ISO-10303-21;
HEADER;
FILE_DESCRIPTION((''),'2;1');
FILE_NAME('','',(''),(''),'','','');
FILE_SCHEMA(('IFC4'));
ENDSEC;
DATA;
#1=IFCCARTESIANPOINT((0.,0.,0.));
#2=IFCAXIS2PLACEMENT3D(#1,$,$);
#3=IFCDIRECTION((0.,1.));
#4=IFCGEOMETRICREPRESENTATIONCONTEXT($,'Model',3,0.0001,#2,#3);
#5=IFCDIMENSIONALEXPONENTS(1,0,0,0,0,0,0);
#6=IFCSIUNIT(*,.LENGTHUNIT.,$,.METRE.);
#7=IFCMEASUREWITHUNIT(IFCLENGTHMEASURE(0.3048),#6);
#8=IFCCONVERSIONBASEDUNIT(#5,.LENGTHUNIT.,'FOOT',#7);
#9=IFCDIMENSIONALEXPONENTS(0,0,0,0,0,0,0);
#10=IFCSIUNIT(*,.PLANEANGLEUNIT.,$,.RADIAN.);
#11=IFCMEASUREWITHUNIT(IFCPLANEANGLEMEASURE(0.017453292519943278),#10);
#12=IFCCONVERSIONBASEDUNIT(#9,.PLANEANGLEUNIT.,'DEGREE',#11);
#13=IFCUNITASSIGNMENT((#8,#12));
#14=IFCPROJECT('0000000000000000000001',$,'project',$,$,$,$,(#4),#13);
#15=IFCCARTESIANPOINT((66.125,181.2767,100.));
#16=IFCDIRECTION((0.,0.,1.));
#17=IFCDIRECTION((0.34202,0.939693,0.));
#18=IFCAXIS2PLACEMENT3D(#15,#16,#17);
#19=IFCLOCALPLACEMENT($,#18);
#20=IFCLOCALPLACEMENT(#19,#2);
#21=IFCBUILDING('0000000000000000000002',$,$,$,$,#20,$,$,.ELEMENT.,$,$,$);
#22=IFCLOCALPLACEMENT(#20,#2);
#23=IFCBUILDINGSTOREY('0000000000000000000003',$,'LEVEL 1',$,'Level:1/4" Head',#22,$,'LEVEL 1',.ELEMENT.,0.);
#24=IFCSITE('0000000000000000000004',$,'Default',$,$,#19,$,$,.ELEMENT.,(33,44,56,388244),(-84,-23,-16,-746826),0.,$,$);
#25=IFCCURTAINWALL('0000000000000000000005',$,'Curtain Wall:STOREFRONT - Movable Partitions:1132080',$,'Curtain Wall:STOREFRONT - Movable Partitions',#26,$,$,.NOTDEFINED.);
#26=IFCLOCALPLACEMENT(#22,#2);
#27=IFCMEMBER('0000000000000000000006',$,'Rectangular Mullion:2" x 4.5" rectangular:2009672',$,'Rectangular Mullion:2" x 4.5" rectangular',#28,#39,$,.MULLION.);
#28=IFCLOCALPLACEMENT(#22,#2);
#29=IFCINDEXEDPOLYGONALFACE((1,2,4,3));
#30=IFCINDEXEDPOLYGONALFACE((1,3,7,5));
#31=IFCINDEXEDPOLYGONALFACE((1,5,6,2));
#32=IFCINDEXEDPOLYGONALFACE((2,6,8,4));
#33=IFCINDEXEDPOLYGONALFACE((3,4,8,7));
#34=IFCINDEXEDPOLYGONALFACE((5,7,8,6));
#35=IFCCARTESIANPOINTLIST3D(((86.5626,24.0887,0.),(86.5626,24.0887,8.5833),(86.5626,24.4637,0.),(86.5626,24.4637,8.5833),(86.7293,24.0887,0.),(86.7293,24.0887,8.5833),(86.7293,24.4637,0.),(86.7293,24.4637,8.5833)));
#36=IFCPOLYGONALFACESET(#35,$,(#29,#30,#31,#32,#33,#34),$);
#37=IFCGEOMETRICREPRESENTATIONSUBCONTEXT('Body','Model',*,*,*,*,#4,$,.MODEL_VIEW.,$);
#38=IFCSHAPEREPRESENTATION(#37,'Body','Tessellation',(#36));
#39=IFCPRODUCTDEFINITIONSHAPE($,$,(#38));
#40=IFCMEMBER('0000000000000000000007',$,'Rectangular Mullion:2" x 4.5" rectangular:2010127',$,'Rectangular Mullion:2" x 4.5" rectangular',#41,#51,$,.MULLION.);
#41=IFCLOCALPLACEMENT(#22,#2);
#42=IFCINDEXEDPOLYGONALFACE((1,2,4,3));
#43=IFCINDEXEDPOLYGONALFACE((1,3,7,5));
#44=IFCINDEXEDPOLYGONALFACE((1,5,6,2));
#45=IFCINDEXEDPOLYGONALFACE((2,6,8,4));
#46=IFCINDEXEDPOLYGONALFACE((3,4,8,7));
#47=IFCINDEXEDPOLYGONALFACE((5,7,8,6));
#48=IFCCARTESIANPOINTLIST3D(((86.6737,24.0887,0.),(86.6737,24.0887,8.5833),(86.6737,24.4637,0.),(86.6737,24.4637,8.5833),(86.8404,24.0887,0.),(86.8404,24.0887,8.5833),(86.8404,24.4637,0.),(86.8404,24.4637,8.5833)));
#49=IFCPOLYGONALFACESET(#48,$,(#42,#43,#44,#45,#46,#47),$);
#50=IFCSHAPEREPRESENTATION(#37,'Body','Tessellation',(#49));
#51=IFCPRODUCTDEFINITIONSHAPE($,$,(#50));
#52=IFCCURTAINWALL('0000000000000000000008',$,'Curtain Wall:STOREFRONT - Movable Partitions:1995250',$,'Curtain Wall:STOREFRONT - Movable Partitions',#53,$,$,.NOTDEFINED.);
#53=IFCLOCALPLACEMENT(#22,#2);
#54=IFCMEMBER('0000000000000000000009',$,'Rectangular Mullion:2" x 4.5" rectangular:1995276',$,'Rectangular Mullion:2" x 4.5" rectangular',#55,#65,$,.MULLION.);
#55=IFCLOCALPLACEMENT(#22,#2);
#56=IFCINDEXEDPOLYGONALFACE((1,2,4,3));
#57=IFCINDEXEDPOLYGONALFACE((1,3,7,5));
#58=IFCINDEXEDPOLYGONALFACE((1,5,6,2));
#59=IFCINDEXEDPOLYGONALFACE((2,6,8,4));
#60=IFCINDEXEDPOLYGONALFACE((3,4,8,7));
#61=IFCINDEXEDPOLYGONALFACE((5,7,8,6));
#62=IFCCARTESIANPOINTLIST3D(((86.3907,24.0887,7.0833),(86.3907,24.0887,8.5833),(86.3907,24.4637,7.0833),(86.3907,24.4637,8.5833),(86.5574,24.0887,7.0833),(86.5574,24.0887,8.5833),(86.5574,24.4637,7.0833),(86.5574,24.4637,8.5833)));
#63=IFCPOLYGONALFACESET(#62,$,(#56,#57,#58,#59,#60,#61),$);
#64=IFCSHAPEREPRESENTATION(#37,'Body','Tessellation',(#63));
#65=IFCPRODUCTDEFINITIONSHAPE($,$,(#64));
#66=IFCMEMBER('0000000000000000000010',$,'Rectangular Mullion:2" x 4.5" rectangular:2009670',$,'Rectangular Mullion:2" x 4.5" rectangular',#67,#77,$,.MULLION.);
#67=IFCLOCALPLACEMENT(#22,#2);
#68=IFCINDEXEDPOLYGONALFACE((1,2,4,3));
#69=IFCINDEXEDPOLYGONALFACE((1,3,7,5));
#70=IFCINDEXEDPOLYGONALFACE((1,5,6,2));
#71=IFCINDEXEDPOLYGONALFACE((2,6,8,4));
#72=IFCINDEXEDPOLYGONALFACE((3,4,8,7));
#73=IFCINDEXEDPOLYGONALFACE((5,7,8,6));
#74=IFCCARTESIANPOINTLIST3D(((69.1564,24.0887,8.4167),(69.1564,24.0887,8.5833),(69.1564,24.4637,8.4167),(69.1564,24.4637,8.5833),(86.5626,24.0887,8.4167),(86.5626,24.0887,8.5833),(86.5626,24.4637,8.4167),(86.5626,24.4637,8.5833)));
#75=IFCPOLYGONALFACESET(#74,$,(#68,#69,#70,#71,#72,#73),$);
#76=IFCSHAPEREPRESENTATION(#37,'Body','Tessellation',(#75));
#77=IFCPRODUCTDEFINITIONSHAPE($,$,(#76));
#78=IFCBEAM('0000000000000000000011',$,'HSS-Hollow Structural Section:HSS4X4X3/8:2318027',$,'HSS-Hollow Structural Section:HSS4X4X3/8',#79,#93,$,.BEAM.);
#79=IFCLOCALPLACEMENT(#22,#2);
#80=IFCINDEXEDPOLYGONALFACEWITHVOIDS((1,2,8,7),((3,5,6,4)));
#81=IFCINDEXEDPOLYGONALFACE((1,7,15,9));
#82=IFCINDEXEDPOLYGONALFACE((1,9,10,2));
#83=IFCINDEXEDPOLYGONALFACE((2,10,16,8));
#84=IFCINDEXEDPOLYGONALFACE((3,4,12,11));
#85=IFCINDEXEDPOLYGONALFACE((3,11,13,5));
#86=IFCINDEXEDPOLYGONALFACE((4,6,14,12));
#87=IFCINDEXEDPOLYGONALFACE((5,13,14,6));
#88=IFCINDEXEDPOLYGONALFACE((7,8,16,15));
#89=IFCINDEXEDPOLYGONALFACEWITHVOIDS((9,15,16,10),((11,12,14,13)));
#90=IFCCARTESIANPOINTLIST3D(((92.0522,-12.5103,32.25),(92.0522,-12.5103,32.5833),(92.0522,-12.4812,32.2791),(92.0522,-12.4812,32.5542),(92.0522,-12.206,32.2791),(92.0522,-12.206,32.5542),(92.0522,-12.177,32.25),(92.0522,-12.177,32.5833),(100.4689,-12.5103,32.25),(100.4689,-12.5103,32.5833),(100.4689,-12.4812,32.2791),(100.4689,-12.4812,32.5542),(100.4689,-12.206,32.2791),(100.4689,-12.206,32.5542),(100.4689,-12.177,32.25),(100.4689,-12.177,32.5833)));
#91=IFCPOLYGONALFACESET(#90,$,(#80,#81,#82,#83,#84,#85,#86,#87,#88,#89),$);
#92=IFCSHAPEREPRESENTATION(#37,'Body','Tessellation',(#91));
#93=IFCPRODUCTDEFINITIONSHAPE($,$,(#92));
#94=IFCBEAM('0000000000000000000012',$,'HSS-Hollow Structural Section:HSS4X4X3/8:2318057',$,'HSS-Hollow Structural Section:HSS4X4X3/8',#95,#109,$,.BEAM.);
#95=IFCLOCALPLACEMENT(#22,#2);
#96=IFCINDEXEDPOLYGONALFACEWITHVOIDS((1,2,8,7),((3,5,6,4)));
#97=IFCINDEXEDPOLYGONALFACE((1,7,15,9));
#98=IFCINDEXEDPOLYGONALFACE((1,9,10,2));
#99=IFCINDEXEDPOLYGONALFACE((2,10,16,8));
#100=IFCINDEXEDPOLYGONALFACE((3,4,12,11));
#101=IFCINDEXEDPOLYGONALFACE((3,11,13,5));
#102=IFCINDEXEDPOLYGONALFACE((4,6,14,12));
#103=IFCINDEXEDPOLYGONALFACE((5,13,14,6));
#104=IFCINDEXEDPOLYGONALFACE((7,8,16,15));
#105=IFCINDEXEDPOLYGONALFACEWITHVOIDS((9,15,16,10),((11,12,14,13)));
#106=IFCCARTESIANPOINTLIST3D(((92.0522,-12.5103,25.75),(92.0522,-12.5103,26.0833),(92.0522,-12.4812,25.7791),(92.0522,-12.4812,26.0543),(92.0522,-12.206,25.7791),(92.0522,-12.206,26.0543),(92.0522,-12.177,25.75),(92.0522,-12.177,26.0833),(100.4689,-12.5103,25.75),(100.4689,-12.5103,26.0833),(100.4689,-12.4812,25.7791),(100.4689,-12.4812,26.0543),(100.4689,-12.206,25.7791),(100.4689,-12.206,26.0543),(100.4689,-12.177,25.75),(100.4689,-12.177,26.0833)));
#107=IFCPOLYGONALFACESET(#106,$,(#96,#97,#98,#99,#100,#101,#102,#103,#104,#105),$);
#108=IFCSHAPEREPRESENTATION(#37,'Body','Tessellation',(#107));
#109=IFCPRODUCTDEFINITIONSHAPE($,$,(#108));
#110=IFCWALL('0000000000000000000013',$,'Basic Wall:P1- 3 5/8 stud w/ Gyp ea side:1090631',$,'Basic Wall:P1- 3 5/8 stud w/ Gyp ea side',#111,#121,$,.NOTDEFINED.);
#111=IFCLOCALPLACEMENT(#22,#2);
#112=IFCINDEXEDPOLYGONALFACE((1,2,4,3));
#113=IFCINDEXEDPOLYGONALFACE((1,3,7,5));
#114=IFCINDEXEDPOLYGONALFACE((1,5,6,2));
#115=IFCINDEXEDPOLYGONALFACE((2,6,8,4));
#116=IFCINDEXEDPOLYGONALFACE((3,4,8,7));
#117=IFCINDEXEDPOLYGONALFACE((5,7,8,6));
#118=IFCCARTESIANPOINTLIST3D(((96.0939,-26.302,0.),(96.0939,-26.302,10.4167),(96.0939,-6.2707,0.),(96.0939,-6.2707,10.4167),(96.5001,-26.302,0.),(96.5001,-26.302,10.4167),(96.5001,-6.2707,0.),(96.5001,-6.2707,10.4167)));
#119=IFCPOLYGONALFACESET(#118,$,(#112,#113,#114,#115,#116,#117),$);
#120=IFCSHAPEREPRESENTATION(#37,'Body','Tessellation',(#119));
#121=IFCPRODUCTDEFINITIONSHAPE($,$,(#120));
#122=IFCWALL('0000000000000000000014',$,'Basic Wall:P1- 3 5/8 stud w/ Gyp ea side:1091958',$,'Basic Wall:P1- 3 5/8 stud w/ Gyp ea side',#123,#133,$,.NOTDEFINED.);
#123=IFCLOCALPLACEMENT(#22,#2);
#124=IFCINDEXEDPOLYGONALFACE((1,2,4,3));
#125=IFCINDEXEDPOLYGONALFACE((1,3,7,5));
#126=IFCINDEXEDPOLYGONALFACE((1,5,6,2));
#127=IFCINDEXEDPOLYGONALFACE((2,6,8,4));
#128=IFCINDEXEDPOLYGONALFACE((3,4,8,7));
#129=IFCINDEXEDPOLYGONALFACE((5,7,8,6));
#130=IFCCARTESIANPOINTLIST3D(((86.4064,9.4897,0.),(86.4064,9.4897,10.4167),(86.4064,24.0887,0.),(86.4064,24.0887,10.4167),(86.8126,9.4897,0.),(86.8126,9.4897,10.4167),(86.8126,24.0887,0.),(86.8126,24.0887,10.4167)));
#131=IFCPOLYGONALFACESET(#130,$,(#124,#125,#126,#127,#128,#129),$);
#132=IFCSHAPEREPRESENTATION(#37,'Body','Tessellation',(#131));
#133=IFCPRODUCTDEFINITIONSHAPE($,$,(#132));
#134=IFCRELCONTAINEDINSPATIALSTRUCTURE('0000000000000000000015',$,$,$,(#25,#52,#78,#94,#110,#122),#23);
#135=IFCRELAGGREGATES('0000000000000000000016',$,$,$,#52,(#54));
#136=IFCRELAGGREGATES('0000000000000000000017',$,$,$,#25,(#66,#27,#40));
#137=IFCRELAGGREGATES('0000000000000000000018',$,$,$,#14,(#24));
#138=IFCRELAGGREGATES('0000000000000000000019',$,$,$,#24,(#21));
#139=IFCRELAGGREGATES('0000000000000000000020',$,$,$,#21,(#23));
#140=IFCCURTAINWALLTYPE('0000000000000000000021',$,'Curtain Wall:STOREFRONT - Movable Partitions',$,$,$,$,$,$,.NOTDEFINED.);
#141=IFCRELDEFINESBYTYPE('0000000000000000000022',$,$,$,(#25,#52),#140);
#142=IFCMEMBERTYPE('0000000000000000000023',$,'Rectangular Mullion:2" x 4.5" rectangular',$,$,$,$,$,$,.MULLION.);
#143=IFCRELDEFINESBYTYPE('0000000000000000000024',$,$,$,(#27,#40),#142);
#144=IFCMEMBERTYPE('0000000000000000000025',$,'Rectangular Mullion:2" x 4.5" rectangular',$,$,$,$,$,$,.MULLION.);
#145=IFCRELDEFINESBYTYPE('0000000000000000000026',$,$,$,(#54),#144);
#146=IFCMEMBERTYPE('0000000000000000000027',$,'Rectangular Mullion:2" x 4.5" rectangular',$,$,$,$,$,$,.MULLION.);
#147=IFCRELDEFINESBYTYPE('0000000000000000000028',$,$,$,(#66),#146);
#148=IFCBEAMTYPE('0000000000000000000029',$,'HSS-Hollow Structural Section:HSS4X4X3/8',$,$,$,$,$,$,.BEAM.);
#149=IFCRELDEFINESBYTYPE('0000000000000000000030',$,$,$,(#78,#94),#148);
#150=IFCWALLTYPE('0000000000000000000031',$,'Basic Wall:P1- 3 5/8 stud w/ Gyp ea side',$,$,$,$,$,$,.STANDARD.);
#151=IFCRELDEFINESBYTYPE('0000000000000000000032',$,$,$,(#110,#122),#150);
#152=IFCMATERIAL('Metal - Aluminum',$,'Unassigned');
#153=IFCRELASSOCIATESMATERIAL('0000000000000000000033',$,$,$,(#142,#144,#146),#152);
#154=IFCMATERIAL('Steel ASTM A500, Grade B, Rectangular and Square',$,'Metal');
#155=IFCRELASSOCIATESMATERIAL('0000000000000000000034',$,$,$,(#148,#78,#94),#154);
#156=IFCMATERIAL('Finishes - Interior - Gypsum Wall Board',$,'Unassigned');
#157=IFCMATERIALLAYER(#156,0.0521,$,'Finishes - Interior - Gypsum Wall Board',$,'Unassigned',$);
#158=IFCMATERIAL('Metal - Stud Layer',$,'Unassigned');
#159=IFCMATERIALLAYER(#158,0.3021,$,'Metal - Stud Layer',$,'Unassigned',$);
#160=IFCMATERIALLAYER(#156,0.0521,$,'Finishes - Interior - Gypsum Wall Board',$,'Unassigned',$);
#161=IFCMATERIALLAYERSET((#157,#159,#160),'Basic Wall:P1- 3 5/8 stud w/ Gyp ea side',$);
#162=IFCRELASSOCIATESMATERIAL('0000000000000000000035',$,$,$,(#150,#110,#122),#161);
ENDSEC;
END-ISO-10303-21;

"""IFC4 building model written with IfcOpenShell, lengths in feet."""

from ifc_helpers import new_model, entity, si_unit, converted_unit, direction, frame, frame_2d, origin, origin_2d_with_axis, place, context, subcontext, project, spatial, rectangle, extrude, boolean, source, transform, mapped, material, layer, layer_set, layer_usage, material_profile, profile_set, type_object, type_shapes, element, aggregate, save


model = new_model("IFC4")

# Units and contexts
model_context = context("Model", 3, precision=0.0001, world=origin(), true_north=direction((0.0, 1.0)))
body_context = subcontext(model_context, "Body", "Model", "MODEL_VIEW")
ifc_project = project(units=[converted_unit("LENGTHUNIT", "FOOT", entity("IfcLengthMeasure", 0.3048), si_unit("LENGTHUNIT", "METRE"), dimensions=[1, 0, 0, 0, 0, 0, 0]), converted_unit("PLANEANGLEUNIT", "DEGREE", entity("IfcPlaneAngleMeasure", 0.017453292519943278), si_unit("PLANEANGLEUNIT", "RADIAN"), dimensions=[0, 0, 0, 0, 0, 0, 0])], contexts=[model_context])

# Site, building, storey
site_placement = place(None, frame((66.125, 181.2767, 100.0), z_axis=(0.0, 0.0, 1.0), x_axis=(0.34202, 0.939693, 0.0)))
site = spatial("IfcSite", under=ifc_project, at=site_placement, Name="Default", CompositionType="ELEMENT", RefLatitude=(33, 44, 56, 388244), RefLongitude=(-84, -23, -16, -746826), RefElevation=0.0)
building_placement = place(site_placement, origin())
building = spatial("IfcBuilding", under=site, at=building_placement, CompositionType="ELEMENT")
storey_placement = place(building_placement, origin())
storey = spatial("IfcBuildingStorey", under=building, at=storey_placement, Name="LEVEL 1", ObjectType="Level:1/4\" Head", LongName="LEVEL 1", CompositionType="ELEMENT", Elevation=0.0)

# Curtain wall, members
curtain_wall_type = type_object("IfcCurtainWallType", Name="Curtain Wall:STOREFRONT - Movable Partitions", PredefinedType="NOTDEFINED")
curtain_wall_1_placement = place(storey_placement, origin())
curtain_wall_1 = element("IfcCurtainWall", 1, at=curtain_wall_1_placement, inside=storey, type_object=curtain_wall_type, Name="Curtain Wall:STOREFRONT - Movable Partitions:1132080", ObjectType="Curtain Wall:STOREFRONT - Movable Partitions", PredefinedType="NOTDEFINED")
ifc_material_1 = material(Name="Metal - Aluminum", Category="Unassigned")
ifc_material_profile_1 = material_profile(ifc_material_1, rectangle(XDim=0.1667, YDim=0.375, at=origin_2d_with_axis()), Name="2\" x 4.5\" rectangular")
ifc_profile_set_1 = profile_set([ifc_material_profile_1], Name="2\" x 4.5\" rectangular")
member_type_1 = type_object("IfcMemberType", Name="Rectangular Mullion:2\" x 4.5\" rectangular", PredefinedType="MULLION", material=ifc_profile_set_1)
shared_shape_1 = source(origin(), body_context, "Body", "SweptSolid", [
    extrude(rectangle(XDim=0.1667, YDim=0.375, at=frame_2d((0.0, 0.0), x_axis=(1.0, 0.0))), frame((0.0, 0.0, -8.5833), z_axis=(0.0, 0.0, 1.0), x_axis=(-1.0, 0.0, 0.0)), (0.0, 0.0, 1.0), 8.5833),
])
type_shapes(member_type_1, [shared_shape_1])
member_1_placement = place(curtain_wall_1_placement, frame((86.6459, 24.2762, 0.0), z_axis=(0.0, 0.0, -1.0), x_axis=(1.0, 0.0, 0.0)))
member_1 = element("IfcMember", 2, at=member_1_placement, type_object=member_type_1, Name="Rectangular Mullion:2\" x 4.5\" rectangular:2009672", ObjectType="Rectangular Mullion:2\" x 4.5\" rectangular", PredefinedType="MULLION", context=body_context, shape_type="MappedRepresentation", body=[
    mapped(shared_shape_1, transform((0.0, 0.0, 0.0), scale=1.0)),
])
member_2_placement = place(curtain_wall_1_placement, frame((86.7571, 24.2762, 0.0), z_axis=(0.0, 0.0, -1.0), x_axis=(1.0, 0.0, 0.0)))
member_2 = element("IfcMember", 3, at=member_2_placement, type_object=member_type_1, Name="Rectangular Mullion:2\" x 4.5\" rectangular:2010127", ObjectType="Rectangular Mullion:2\" x 4.5\" rectangular", PredefinedType="MULLION", context=body_context, shape_type="MappedRepresentation", body=[
    mapped(shared_shape_1, transform((0.0, 0.0, 0.0), scale=1.0)),
])

# Curtain wall, member
curtain_wall_2_placement = place(storey_placement, origin())
curtain_wall_2 = element("IfcCurtainWall", 4, at=curtain_wall_2_placement, inside=storey, type_object=curtain_wall_type, Name="Curtain Wall:STOREFRONT - Movable Partitions:1995250", ObjectType="Curtain Wall:STOREFRONT - Movable Partitions", PredefinedType="NOTDEFINED")
member_type_2 = type_object("IfcMemberType", Name="Rectangular Mullion:2\" x 4.5\" rectangular", PredefinedType="MULLION", material=ifc_profile_set_1)
shared_shape_2 = source(origin(), body_context, "Body", "SweptSolid", [
    extrude(rectangle(XDim=0.1667, YDim=0.375, at=origin_2d_with_axis()), frame((-0.0833, 0.0, -1.5), z_axis=(0.0, 0.0, 1.0), x_axis=(-1.0, 0.0, 0.0)), (0.0, 0.0, 1.0), 1.5),
])
type_shapes(member_type_2, [shared_shape_2])
member_3_placement = place(curtain_wall_2_placement, frame((86.5574, 24.2762, 7.0833), z_axis=(0.0, 0.0, -1.0), x_axis=(1.0, 0.0, 0.0)))
member_3 = element("IfcMember", 5, at=member_3_placement, type_object=member_type_2, Name="Rectangular Mullion:2\" x 4.5\" rectangular:1995276", ObjectType="Rectangular Mullion:2\" x 4.5\" rectangular", PredefinedType="MULLION", context=body_context, shape_type="MappedRepresentation", body=[
    mapped(shared_shape_2, transform((0.0, 0.0, 0.0), scale=1.0)),
])
aggregate(curtain_wall_2, [member_3])

# Member
member_type_3 = type_object("IfcMemberType", Name="Rectangular Mullion:2\" x 4.5\" rectangular", PredefinedType="MULLION", material=ifc_profile_set_1)
shared_shape_3 = source(origin(), body_context, "Body", "SweptSolid", [
    extrude(rectangle(XDim=17.4063, YDim=0.375, at=frame_2d((0.0, 0.0), x_axis=(1.0, 0.0))), frame((-0.1667, 0.0, -8.7031), z_axis=(1.0, 0.0, 0.0), x_axis=(0.0, 0.0, -1.0)), (0.0, 0.0, 1.0), 0.1667),
])
type_shapes(member_type_3, [shared_shape_3])
member_4_placement = place(curtain_wall_1_placement, frame((86.5626, 24.2762, 8.5833), z_axis=(1.0, 0.0, 0.0), x_axis=(0.0, 0.0, 1.0)))
member_4 = element("IfcMember", 6, at=member_4_placement, type_object=member_type_3, Name="Rectangular Mullion:2\" x 4.5\" rectangular:2009670", ObjectType="Rectangular Mullion:2\" x 4.5\" rectangular", PredefinedType="MULLION", context=body_context, shape_type="MappedRepresentation", body=[
    mapped(shared_shape_3, transform((0.0, 0.0, 0.0), scale=1.0)),
])
aggregate(curtain_wall_1, [member_4, member_1, member_2])

# Beams
ifc_material_2 = material(Name="Steel ASTM A500, Grade B, Rectangular and Square", Category="Metal")
ifc_material_profile_2 = material_profile(ifc_material_2, rectangle(XDim=0.3333, YDim=0.3333, at=origin_2d_with_axis()), Name="HSS4X4X3/8")
ifc_profile_set_2 = profile_set([ifc_material_profile_2], Name="HSS4X4X3/8")
beam_type_1 = type_object("IfcBeamType", Name="HSS-Hollow Structural Section:HSS4X4X3/8", PredefinedType="BEAM", material=ifc_profile_set_2)
shared_shape_4 = source(origin(), body_context, "Body", "SweptSolid", [
    boolean("DIFFERENCE", extrude(rectangle(XDim=0.3333, YDim=0.3333, at=origin_2d_with_axis()), frame((-4.2083, 0.0, 0.0), z_axis=(1.0, 0.0, 0.0), x_axis=(0.0, 0.0, -1.0)), (0.0, 0.0, 1.0), 8.4167), extrude(rectangle(XDim=0.2752, YDim=0.2752, at=frame_2d((0.0, 0.0), x_axis=(0.0, 1.0))), frame((-4.2083, 0.0, 0.0), z_axis=(1.0, 0.0, 0.0), x_axis=(0.0, -1.0, 0.0)), (0.0, 0.0, 1.0), 8.4167)),
])
type_shapes(beam_type_1, [shared_shape_4])
for number, where, z_axis, x_axis, name in (
    (7, (96.2605, -12.3436, 32.4167), (0.0, 0.0, 1.0), (-1.0, 0.0, 0.0), "HSS-Hollow Structural Section:HSS4X4X3/8:2318027"),
    (8, (96.2605, -12.3436, 25.9167), (0.0, 0.0, 1.0), (-1.0, 0.0, 0.0), "HSS-Hollow Structural Section:HSS4X4X3/8:2318057"),
):
    element("IfcBeam", number, at=place(storey_placement, frame(where, z_axis=z_axis, x_axis=x_axis)), inside=storey, type_object=beam_type_1, material=ifc_material_2, Name=name, ObjectType="HSS-Hollow Structural Section:HSS4X4X3/8", PredefinedType="BEAM", context=body_context, shape_type="MappedRepresentation", body=[
        mapped(shared_shape_4, transform((0.0, 0.0, 0.0), scale=1.0)),
    ])

# Walls
ifc_material_3 = material(Name="Finishes - Interior - Gypsum Wall Board", Category="Unassigned")
ifc_layer_1 = layer(ifc_material_3, 0.0521, Name="Finishes - Interior - Gypsum Wall Board", Category="Unassigned")
ifc_material_4 = material(Name="Metal - Stud Layer", Category="Unassigned")
ifc_layer_2 = layer(ifc_material_4, 0.3021, Name="Metal - Stud Layer", Category="Unassigned")
ifc_layer_3 = layer(ifc_material_3, 0.0521, Name="Finishes - Interior - Gypsum Wall Board", Category="Unassigned")
ifc_layer_set = layer_set([ifc_layer_1, ifc_layer_2, ifc_layer_3], Name="Basic Wall:P1- 3 5/8 stud w/ Gyp ea side")
ifc_layer_usage_1 = layer_usage(ifc_layer_set, "AXIS2", "NEGATIVE", 0.2031)
wall_type = type_object("IfcWallType", Name="Basic Wall:P1- 3 5/8 stud w/ Gyp ea side", PredefinedType="STANDARD", material=ifc_layer_set)
wall_1_placement = place(storey_placement, frame((96.297, -6.2707, 0.0), z_axis=(0.0, 0.0, 1.0), x_axis=(0.0, -1.0, 0.0)))
element("IfcWall", 9, at=wall_1_placement, inside=storey, type_object=wall_type, material=ifc_layer_usage_1, Name="Basic Wall:P1- 3 5/8 stud w/ Gyp ea side:1090631", ObjectType="Basic Wall:P1- 3 5/8 stud w/ Gyp ea side", PredefinedType="NOTDEFINED", context=body_context, shape_type="SweptSolid", body=[
    extrude(rectangle(XDim=20.0312, YDim=0.4062, at=frame_2d((10.0156, 0.0), x_axis=(-1.0, 0.0))), origin(), (0.0, 0.0, 1.0), 10.4167),
])
ifc_layer_usage_2 = layer_usage(ifc_layer_set, "AXIS2", "POSITIVE", -0.2031)
wall_2_placement = place(storey_placement, frame((86.6095, 9.4897, 0.0), z_axis=(0.0, 0.0, 1.0), x_axis=(0.0, 1.0, 0.0)))
element("IfcWall", 10, at=wall_2_placement, inside=storey, type_object=wall_type, material=ifc_layer_usage_2, Name="Basic Wall:P1- 3 5/8 stud w/ Gyp ea side:1091958", ObjectType="Basic Wall:P1- 3 5/8 stud w/ Gyp ea side", PredefinedType="NOTDEFINED", context=body_context, shape_type="SweptSolid", body=[
    extrude(rectangle(XDim=14.599, YDim=0.4062, at=frame_2d((7.2995, 0.0), x_axis=(-1.0, 0.0))), origin(), (0.0, 0.0, 1.0), 10.4167),
])

save(model, "model.ifc")
